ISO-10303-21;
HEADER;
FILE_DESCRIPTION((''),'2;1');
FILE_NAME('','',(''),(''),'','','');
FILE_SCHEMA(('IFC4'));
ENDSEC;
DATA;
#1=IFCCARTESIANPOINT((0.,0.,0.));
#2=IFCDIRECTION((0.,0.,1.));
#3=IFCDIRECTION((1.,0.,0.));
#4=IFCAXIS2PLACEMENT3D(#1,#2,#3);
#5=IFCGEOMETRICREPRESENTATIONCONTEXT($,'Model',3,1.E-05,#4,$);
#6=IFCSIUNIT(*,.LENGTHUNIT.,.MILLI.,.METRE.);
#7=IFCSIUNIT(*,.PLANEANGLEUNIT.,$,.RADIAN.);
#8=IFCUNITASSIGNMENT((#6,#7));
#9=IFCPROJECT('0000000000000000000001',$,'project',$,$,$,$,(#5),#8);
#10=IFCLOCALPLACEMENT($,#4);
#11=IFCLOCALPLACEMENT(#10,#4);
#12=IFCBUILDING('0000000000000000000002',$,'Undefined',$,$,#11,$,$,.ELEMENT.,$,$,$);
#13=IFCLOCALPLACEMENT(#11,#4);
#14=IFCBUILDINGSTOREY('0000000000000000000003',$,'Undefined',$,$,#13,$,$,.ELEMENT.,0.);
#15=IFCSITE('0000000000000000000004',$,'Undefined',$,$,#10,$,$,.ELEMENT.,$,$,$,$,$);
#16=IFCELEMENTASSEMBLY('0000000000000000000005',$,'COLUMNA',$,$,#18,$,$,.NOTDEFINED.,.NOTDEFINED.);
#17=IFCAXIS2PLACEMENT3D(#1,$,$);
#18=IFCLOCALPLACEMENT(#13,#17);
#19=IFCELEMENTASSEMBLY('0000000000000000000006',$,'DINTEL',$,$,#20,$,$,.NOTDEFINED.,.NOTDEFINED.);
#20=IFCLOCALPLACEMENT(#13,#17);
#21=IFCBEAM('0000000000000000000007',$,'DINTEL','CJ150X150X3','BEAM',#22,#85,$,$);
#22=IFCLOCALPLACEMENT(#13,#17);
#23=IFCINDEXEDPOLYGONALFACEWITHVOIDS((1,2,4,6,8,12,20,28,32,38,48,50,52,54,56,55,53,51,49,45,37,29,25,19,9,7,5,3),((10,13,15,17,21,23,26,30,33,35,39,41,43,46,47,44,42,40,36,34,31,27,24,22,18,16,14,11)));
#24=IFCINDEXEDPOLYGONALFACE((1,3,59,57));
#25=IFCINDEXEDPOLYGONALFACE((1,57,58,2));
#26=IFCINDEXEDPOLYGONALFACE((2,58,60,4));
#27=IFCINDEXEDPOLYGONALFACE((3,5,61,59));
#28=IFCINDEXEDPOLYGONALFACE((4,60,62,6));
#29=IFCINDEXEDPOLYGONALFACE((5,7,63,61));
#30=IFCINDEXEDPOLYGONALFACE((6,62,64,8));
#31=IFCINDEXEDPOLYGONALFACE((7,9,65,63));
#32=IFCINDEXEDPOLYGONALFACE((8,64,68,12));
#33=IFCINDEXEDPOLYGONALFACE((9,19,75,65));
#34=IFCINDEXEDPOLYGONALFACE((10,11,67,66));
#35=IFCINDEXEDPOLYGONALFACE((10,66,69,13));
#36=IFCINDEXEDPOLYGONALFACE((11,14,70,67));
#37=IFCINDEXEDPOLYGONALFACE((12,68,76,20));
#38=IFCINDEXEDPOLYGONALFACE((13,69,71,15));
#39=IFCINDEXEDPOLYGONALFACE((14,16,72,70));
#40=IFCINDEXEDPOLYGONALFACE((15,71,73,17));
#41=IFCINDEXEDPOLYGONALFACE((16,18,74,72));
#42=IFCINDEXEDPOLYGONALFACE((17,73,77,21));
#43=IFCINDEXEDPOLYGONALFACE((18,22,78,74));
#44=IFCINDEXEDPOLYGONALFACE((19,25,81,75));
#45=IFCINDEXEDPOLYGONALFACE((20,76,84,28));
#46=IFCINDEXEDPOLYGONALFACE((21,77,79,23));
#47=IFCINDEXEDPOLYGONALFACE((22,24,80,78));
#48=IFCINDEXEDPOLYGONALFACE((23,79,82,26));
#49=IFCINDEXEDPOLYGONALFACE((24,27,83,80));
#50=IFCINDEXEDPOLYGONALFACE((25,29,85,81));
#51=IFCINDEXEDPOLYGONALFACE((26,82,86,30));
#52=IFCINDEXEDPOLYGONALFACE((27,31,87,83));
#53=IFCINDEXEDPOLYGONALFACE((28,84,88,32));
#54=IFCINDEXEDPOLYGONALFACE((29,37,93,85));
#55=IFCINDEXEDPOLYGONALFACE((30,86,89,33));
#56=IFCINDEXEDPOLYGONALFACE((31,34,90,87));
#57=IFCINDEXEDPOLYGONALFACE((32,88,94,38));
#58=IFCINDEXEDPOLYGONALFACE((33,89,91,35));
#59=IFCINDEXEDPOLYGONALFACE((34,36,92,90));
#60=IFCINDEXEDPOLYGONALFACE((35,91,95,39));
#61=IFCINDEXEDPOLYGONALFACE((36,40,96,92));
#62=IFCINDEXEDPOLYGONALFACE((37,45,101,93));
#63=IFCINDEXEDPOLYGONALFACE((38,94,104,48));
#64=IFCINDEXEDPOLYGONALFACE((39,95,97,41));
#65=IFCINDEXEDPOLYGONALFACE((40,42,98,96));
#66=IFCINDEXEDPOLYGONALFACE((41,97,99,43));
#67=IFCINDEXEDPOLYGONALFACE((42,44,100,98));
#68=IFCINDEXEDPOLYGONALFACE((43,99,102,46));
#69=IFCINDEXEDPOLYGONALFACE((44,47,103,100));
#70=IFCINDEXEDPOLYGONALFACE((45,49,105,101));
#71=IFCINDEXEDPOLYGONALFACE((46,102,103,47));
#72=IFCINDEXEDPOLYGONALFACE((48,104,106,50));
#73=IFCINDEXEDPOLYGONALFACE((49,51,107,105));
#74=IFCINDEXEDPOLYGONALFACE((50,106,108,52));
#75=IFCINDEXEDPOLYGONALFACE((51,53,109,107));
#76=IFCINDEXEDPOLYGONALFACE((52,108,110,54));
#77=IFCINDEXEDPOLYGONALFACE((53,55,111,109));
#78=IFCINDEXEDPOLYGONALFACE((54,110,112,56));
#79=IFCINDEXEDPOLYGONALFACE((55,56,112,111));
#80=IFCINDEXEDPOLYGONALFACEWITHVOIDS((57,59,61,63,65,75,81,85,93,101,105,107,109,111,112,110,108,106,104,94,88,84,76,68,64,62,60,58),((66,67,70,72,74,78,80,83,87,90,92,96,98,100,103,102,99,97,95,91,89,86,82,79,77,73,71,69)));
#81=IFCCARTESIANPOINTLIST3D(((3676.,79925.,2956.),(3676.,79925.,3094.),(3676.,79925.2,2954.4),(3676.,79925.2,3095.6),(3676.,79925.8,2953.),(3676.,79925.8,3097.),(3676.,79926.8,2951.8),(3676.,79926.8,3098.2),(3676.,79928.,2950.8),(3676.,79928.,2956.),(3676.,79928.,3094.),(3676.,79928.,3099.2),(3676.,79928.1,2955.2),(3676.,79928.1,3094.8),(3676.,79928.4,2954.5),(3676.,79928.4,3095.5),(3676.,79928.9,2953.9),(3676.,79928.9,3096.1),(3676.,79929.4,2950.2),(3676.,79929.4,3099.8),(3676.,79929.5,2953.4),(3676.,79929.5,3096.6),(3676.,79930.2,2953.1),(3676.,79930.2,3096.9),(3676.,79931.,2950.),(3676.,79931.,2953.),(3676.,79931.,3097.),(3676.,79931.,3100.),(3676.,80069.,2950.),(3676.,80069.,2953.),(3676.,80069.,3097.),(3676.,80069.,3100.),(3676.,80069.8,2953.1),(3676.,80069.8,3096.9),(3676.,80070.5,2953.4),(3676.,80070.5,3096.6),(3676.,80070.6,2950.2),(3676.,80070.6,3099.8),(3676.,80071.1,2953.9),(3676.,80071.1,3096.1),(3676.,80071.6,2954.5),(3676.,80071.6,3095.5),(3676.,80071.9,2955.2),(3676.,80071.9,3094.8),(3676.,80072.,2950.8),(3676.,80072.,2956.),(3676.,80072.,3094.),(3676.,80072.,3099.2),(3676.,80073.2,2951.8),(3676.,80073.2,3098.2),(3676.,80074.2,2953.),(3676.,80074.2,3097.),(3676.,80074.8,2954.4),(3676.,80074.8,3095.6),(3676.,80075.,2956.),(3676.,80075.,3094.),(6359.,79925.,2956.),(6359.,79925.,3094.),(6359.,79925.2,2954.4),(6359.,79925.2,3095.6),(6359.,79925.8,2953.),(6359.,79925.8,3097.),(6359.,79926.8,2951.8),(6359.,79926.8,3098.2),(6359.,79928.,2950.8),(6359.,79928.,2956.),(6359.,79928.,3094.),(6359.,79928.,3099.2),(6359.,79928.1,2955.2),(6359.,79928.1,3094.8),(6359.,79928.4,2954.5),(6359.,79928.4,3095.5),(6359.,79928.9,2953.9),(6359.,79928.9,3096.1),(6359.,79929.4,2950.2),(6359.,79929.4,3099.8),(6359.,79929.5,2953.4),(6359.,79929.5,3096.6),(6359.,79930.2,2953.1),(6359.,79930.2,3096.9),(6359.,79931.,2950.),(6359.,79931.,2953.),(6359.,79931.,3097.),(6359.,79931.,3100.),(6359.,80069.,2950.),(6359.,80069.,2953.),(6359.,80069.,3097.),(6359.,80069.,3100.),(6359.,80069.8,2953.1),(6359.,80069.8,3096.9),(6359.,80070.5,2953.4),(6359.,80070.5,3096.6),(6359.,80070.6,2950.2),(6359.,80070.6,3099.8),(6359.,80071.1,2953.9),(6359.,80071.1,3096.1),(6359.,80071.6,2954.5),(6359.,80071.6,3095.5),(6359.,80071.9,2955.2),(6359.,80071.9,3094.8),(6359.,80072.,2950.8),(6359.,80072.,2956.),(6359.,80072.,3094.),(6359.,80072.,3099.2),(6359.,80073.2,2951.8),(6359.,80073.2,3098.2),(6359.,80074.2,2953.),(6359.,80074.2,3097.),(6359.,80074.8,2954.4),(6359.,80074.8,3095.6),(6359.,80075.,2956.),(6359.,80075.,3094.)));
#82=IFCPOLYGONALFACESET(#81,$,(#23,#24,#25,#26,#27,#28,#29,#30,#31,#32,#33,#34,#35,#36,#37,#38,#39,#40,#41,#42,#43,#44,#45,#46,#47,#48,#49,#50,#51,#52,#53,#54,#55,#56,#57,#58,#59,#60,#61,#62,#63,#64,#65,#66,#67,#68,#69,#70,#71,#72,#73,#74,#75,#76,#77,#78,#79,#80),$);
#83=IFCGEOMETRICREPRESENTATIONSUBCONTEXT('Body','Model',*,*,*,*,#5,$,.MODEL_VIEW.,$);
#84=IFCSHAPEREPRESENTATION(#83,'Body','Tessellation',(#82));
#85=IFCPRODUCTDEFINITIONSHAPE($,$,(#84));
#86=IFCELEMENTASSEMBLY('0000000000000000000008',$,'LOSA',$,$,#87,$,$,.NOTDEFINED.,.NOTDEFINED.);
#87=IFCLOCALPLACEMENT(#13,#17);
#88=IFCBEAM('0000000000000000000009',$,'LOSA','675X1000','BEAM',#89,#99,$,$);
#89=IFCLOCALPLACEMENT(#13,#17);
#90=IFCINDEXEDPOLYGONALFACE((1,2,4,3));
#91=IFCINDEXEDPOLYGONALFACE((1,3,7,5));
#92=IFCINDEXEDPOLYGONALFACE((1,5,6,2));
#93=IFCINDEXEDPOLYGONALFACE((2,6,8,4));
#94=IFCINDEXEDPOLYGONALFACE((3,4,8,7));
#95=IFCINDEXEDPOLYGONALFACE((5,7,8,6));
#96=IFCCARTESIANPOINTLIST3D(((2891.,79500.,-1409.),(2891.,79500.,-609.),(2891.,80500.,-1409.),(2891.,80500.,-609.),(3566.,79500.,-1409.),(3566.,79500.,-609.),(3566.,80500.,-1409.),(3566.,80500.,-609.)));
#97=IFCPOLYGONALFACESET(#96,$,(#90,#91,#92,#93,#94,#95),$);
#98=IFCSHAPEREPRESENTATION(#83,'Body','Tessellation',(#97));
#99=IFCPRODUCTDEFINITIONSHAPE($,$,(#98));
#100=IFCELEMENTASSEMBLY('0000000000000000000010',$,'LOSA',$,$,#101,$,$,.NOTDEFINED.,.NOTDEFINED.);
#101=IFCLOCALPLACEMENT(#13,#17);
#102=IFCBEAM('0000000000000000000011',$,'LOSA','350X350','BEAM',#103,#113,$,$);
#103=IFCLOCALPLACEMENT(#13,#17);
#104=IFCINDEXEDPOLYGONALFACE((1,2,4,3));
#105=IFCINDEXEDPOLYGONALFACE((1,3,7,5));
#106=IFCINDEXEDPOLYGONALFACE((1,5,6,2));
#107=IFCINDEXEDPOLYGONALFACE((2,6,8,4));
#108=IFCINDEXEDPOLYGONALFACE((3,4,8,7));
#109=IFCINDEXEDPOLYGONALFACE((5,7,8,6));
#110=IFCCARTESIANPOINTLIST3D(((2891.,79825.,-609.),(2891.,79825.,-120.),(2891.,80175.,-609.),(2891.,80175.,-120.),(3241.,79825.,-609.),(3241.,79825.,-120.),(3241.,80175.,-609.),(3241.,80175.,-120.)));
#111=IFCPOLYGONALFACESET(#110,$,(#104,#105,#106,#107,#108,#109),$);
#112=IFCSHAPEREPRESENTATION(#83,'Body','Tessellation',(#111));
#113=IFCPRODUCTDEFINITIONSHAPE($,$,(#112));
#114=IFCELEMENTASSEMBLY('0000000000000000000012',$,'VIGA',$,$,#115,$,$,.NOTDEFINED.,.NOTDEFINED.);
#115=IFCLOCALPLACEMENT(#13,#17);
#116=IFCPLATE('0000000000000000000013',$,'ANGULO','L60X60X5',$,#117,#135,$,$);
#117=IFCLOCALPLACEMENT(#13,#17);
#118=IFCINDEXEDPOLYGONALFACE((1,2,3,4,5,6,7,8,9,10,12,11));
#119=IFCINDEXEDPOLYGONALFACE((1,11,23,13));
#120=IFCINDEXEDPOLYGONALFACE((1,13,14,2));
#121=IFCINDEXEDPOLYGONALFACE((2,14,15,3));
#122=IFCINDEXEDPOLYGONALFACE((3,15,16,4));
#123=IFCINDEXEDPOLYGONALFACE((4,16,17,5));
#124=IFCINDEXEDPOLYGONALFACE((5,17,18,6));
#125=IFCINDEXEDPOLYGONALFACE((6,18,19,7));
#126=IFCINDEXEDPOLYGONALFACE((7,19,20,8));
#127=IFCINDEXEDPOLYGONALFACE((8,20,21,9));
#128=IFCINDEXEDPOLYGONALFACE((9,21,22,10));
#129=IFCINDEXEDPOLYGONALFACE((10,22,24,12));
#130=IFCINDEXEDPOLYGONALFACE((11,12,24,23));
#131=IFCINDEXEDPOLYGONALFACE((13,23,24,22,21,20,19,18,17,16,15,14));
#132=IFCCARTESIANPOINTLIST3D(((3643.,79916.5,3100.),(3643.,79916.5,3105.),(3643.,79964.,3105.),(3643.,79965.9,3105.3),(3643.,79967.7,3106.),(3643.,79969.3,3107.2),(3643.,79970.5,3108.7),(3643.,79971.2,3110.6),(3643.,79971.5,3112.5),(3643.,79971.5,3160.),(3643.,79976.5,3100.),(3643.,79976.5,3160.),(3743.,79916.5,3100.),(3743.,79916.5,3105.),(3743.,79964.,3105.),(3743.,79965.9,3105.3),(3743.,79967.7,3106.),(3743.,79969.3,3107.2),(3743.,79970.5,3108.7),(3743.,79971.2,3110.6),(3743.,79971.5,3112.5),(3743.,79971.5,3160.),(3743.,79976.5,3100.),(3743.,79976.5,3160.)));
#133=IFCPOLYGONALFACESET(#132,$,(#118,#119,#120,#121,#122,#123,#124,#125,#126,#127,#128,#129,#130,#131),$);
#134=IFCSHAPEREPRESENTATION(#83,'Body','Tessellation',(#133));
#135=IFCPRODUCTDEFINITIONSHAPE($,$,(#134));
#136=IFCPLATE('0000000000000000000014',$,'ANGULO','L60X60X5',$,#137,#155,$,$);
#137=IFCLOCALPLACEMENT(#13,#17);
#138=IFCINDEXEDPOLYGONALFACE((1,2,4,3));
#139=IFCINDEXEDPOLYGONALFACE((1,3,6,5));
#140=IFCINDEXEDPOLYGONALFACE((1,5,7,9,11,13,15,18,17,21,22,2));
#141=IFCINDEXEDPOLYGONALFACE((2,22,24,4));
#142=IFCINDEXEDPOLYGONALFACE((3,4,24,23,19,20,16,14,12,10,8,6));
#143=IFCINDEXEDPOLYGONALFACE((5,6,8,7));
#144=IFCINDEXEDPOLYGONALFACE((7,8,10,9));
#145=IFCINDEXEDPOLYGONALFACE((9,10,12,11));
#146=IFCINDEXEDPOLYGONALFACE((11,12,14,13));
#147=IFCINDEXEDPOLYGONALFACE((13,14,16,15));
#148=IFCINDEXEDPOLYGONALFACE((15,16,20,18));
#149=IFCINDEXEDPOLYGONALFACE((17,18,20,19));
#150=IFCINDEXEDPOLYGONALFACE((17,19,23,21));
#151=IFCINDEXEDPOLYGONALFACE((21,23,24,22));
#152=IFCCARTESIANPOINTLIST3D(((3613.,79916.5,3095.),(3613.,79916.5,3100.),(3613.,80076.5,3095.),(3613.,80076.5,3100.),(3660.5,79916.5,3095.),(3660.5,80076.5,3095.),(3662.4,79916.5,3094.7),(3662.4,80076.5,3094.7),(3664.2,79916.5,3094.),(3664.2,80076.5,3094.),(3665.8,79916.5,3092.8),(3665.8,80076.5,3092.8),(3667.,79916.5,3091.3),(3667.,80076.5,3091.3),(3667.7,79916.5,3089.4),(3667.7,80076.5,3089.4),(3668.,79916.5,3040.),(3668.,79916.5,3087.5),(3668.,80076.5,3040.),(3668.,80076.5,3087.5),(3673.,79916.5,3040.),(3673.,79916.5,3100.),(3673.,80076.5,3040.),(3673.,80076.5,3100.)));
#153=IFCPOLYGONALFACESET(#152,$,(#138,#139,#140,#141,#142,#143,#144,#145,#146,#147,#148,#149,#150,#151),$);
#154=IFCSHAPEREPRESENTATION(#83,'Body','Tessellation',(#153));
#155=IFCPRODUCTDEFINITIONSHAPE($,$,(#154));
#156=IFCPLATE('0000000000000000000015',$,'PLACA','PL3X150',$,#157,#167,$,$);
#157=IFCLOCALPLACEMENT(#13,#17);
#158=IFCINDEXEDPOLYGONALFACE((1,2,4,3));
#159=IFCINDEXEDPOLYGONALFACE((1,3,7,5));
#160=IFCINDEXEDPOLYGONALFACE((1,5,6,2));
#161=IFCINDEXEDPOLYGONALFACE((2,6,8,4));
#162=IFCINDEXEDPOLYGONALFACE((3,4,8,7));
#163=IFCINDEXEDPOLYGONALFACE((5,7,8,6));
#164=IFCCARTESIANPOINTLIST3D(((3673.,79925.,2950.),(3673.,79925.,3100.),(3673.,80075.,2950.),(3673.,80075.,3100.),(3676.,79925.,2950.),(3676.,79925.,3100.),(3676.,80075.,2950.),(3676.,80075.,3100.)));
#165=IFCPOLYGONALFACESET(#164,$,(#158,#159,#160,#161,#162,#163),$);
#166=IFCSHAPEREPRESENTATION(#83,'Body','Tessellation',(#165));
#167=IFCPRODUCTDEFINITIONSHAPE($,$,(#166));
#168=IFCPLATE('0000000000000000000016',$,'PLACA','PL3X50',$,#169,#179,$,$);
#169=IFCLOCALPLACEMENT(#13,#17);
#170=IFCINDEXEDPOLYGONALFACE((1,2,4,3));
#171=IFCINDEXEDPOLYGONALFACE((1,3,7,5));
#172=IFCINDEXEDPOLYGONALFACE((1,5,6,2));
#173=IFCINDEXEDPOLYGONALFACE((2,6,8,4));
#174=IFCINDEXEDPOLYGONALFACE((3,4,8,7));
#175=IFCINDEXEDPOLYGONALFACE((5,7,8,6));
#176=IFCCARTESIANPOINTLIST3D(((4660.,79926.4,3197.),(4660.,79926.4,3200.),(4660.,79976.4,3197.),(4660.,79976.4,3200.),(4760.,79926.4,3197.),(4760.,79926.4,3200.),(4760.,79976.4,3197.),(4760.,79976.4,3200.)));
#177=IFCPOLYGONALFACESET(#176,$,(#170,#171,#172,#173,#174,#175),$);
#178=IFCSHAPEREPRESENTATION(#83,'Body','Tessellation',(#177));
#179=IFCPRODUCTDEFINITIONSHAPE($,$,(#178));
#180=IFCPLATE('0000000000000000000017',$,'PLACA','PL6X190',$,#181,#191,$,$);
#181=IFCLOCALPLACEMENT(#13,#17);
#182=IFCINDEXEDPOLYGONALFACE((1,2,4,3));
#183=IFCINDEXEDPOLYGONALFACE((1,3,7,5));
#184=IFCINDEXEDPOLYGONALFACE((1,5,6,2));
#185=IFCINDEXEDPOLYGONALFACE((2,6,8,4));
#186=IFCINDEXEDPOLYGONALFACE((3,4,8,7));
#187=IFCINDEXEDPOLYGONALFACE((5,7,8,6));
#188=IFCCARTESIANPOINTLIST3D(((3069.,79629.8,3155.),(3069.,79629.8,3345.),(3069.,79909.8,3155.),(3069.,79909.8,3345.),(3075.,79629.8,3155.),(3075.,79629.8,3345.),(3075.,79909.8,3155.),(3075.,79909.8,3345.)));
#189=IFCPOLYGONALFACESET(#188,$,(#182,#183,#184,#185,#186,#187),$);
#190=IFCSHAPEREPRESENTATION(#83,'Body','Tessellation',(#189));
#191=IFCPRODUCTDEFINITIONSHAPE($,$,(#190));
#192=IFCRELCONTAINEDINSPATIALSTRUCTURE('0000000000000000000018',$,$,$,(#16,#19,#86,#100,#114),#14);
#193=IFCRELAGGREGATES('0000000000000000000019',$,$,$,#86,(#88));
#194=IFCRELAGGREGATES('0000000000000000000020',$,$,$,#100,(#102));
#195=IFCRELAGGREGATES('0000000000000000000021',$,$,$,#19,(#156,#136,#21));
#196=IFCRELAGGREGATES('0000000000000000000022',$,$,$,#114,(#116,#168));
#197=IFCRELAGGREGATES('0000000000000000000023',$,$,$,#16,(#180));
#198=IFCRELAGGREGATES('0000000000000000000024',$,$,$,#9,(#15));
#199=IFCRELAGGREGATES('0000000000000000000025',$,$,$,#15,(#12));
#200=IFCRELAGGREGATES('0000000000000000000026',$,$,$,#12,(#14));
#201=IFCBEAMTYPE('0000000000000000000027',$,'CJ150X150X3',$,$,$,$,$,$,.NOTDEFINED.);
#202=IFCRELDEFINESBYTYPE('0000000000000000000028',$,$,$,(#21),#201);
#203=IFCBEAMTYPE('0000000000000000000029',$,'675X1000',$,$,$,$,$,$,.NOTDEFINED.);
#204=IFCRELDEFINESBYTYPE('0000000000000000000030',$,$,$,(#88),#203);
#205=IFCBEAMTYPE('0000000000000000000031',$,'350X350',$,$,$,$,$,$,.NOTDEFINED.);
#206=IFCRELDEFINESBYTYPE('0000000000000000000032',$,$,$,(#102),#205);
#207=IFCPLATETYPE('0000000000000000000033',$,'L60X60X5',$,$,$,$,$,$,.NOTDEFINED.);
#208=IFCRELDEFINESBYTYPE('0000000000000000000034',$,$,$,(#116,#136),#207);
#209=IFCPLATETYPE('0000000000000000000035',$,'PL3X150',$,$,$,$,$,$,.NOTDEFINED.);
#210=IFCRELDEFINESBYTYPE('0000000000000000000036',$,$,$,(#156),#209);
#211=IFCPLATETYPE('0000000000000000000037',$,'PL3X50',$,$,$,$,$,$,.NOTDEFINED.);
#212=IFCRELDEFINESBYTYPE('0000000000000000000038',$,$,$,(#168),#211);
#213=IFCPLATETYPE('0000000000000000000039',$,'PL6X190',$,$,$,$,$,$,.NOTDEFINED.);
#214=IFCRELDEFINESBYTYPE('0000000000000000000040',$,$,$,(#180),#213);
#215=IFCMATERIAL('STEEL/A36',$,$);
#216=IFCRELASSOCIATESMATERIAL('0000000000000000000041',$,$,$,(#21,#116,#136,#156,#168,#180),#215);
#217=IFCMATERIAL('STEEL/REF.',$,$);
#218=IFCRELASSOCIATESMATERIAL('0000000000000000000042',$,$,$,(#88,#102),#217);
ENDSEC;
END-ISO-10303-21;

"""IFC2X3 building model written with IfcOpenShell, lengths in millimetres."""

from ifc_helpers import new_model, si_unit, frame, origin_with_axes, origin_2d_with_axis, place, context, subcontext, project, spatial, polyline, rectangle, hollow_rectangle, l_section, outline, extrude, material, type_object, element, aggregate, save


model = new_model("IFC2X3")

# Units and contexts
model_context = context("Model", 3, precision=1e-05, world=origin_with_axes())
body_context = subcontext(model_context, "Body", "Model", "MODEL_VIEW")
ifc_project = project(units=[si_unit("LENGTHUNIT", "METRE", prefix="MILLI"), si_unit("PLANEANGLEUNIT", "RADIAN")], contexts=[model_context])

# Site, building, storey
site_placement = place(None, origin_with_axes())
site = spatial("IfcSite", under=ifc_project, at=site_placement, Name="Undefined", CompositionType="ELEMENT")
building_placement = place(site_placement, origin_with_axes())
building = spatial("IfcBuilding", under=site, at=building_placement, Name="Undefined", CompositionType="ELEMENT")
storey_placement = place(building_placement, origin_with_axes())
storey = spatial("IfcBuildingStorey", under=building, at=storey_placement, Name="Undefined", CompositionType="ELEMENT", Elevation=0.0)

# Element assembly
assembly_1_placement = place(storey_placement, origin_with_axes())
assembly_1 = element("IfcElementAssembly", 1, at=assembly_1_placement, inside=storey, Name="COLUMNA", AssemblyPlace="NOTDEFINED", PredefinedType="NOTDEFINED")
ifc_material_1 = material(Name="STEEL/A36")

# Element assemblies, beams
assembly_2_placement = place(storey_placement, origin_with_axes())
assembly_2 = element("IfcElementAssembly", 2, at=assembly_2_placement, inside=storey, Name="DINTEL", AssemblyPlace="NOTDEFINED", PredefinedType="NOTDEFINED")
beam_type_1 = type_object("IfcBeamType", Name="CJ150X150X3", PredefinedType="NOTDEFINED")
beam_1_placement = place(assembly_2_placement, frame((3676.0, 80000.0, 3025.0), z_axis=(0.0, 0.0, 1.0), x_axis=(1.0, 0.0, 0.0)))
beam_1 = element("IfcBeam", 3, at=beam_1_placement, type_object=beam_type_1, material=ifc_material_1, Name="DINTEL", Description="CJ150X150X3", ObjectType="BEAM", context=body_context, shape_type="SweptSolid", body=[
    extrude(hollow_rectangle(XDim=150.0, YDim=150.0, WallThickness=3.0, InnerFilletRadius=3.0, OuterFilletRadius=6.0, at=origin_2d_with_axis()), frame((2683.0, 0.0, 0.0), z_axis=(-1.0, 0.0, 0.0), x_axis=(0.0, -1.0, 0.0)), (0.0, 0.0, 1.0), 2683.0),
])
assembly_3_placement = place(storey_placement, origin_with_axes())
assembly_3 = element("IfcElementAssembly", 4, at=assembly_3_placement, inside=storey, Name="LOSA", AssemblyPlace="NOTDEFINED", PredefinedType="NOTDEFINED")
ifc_material_2 = material(Name="STEEL/REF.")
beam_type_2 = type_object("IfcBeamType", Name="675X1000", PredefinedType="NOTDEFINED")
beam_2_placement = place(assembly_3_placement, frame((3228.5, 80000.0, -609.0), z_axis=(1.0, 0.0, 0.0), x_axis=(0.0, 0.0, -1.0)))
beam_2 = element("IfcBeam", 5, at=beam_2_placement, type_object=beam_type_2, material=ifc_material_2, Name="LOSA", Description="675X1000", ObjectType="BEAM", context=body_context, shape_type="SweptSolid", body=[
    extrude(rectangle(XDim=1000.0, YDim=675.0, at=origin_2d_with_axis()), frame((800.0, 0.0, 0.0), z_axis=(-1.0, 0.0, 0.0), x_axis=(0.0, -1.0, 0.0)), (0.0, 0.0, 1.0), 800.0),
])
aggregate(assembly_3, [beam_2])
assembly_4_placement = place(storey_placement, origin_with_axes())
assembly_4 = element("IfcElementAssembly", 6, at=assembly_4_placement, inside=storey, Name="LOSA", AssemblyPlace="NOTDEFINED", PredefinedType="NOTDEFINED")
beam_type_3 = type_object("IfcBeamType", Name="350X350", PredefinedType="NOTDEFINED")
beam_3_placement = place(assembly_4_placement, frame((3066.0, 80000.0, -120.0), z_axis=(1.0, 0.0, 0.0), x_axis=(0.0, 0.0, -1.0)))
beam_3 = element("IfcBeam", 7, at=beam_3_placement, type_object=beam_type_3, material=ifc_material_2, Name="LOSA", Description="350X350", ObjectType="BEAM", context=body_context, shape_type="SweptSolid", body=[
    extrude(rectangle(XDim=350.0, YDim=350.0, at=origin_2d_with_axis()), frame((489.0, 0.0, 0.0), z_axis=(-1.0, 0.0, 0.0), x_axis=(0.0, -1.0, 0.0)), (0.0, 0.0, 1.0), 489.0),
])
aggregate(assembly_4, [beam_3])

# Element assembly, plate
assembly_5_placement = place(storey_placement, origin_with_axes())
assembly_5 = element("IfcElementAssembly", 8, at=assembly_5_placement, inside=storey, Name="VIGA", AssemblyPlace="NOTDEFINED", PredefinedType="NOTDEFINED")
plate_type_1 = type_object("IfcPlateType", Name="L60X60X5", PredefinedType="NOTDEFINED")
plate_1_placement = place(assembly_5_placement, frame((3643.0, 79946.5, 3130.0), z_axis=(0.0, 0.0, 1.0), x_axis=(1.0, 0.0, 0.0)))
plate_1 = element("IfcPlate", 9, at=plate_1_placement, type_object=plate_type_1, material=ifc_material_1, Name="ANGULO", Description="L60X60X5", context=body_context, shape_type="SweptSolid", body=[
    extrude(l_section(Depth=60.0, Width=60.0, Thickness=5.0, FilletRadius=7.5, at=origin_2d_with_axis()), frame((100.0, 0.0, 0.0), z_axis=(-1.0, 0.0, 0.0), x_axis=(0.0, -1.0, 0.0)), (0.0, 0.0, 1.0), 100.0),
])

# Plates
plate_2_placement = place(assembly_2_placement, frame((3643.0, 79916.5, 3070.0), z_axis=(0.0, 0.0, -1.0), x_axis=(0.0, 1.0, 0.0)))
plate_2 = element("IfcPlate", 10, at=plate_2_placement, type_object=plate_type_1, material=ifc_material_1, Name="ANGULO", Description="L60X60X5", context=body_context, shape_type="SweptSolid", body=[
    extrude(l_section(Depth=60.0, Width=60.0, Thickness=5.0, FilletRadius=7.5, at=origin_2d_with_axis()), frame((160.0, 0.0, 0.0), z_axis=(-1.0, 0.0, 0.0), x_axis=(0.0, -1.0, 0.0)), (0.0, 0.0, 1.0), 160.0),
])
plate_type_2 = type_object("IfcPlateType", Name="PL3X150", PredefinedType="NOTDEFINED")
plate_3_placement = place(assembly_2_placement, frame((3674.5, 79925.0, 2950.0), z_axis=(1.0, 0.0, 0.0), x_axis=(0.0, 1.0, 0.0)))
plate_3 = element("IfcPlate", 11, at=plate_3_placement, type_object=plate_type_2, material=ifc_material_1, Name="PLACA", Description="PL3X150", context=body_context, shape_type="SweptSolid", body=[
    extrude(outline(polyline([(0.0, 0.0), (150.0, 0.0), (150.0, 150.0), (0.0, 150.0), (0.0, 0.0)])), frame((0.0, 0.0, -1.5), z_axis=(0.0, 0.0, 1.0), x_axis=(1.0, 0.0, 0.0)), (0.0, 0.0, 1.0), 3.0),
])
aggregate(assembly_2, [plate_3, plate_2, beam_1])
plate_type_3 = type_object("IfcPlateType", Name="PL3X50", PredefinedType="NOTDEFINED")
plate_4_placement = place(assembly_5_placement, frame((4660.0, 79976.4, 3198.5), z_axis=(0.0, 0.0, 1.0), x_axis=(0.0, -1.0, 0.0)))
plate_4 = element("IfcPlate", 12, at=plate_4_placement, type_object=plate_type_3, material=ifc_material_1, Name="PLACA", Description="PL3X50", context=body_context, shape_type="SweptSolid", body=[
    extrude(outline(polyline([(0.0, 0.0), (50.0, 0.0), (50.0, 100.0), (0.0, 100.0), (0.0, 0.0)])), frame((0.0, 0.0, -1.5), z_axis=(0.0, 0.0, 1.0), x_axis=(1.0, 0.0, 0.0)), (0.0, 0.0, 1.0), 3.0),
])
plate_type_4 = type_object("IfcPlateType", Name="PL6X190", PredefinedType="NOTDEFINED")
plate_5_placement = place(assembly_1_placement, frame((3072.0, 79629.8, 3250.0), z_axis=(1.0, 0.0, 0.0), x_axis=(0.0, 1.0, 0.0)))
plate_5 = element("IfcPlate", 13, at=plate_5_placement, type_object=plate_type_4, material=ifc_material_1, Name="PLACA", Description="PL6X190", context=body_context, shape_type="SweptSolid", body=[
    extrude(outline(polyline([(0.0, -95.0), (0.0, 95.0), (280.0, 95.0), (280.0, -95.0), (0.0, -95.0)])), frame((0.0, 0.0, -3.0), z_axis=(0.0, 0.0, 1.0), x_axis=(1.0, 0.0, 0.0)), (0.0, 0.0, 1.0), 6.0),
])

aggregate(assembly_5, [plate_1, plate_4])

aggregate(assembly_1, [plate_5])

save(model, "model.ifc")
